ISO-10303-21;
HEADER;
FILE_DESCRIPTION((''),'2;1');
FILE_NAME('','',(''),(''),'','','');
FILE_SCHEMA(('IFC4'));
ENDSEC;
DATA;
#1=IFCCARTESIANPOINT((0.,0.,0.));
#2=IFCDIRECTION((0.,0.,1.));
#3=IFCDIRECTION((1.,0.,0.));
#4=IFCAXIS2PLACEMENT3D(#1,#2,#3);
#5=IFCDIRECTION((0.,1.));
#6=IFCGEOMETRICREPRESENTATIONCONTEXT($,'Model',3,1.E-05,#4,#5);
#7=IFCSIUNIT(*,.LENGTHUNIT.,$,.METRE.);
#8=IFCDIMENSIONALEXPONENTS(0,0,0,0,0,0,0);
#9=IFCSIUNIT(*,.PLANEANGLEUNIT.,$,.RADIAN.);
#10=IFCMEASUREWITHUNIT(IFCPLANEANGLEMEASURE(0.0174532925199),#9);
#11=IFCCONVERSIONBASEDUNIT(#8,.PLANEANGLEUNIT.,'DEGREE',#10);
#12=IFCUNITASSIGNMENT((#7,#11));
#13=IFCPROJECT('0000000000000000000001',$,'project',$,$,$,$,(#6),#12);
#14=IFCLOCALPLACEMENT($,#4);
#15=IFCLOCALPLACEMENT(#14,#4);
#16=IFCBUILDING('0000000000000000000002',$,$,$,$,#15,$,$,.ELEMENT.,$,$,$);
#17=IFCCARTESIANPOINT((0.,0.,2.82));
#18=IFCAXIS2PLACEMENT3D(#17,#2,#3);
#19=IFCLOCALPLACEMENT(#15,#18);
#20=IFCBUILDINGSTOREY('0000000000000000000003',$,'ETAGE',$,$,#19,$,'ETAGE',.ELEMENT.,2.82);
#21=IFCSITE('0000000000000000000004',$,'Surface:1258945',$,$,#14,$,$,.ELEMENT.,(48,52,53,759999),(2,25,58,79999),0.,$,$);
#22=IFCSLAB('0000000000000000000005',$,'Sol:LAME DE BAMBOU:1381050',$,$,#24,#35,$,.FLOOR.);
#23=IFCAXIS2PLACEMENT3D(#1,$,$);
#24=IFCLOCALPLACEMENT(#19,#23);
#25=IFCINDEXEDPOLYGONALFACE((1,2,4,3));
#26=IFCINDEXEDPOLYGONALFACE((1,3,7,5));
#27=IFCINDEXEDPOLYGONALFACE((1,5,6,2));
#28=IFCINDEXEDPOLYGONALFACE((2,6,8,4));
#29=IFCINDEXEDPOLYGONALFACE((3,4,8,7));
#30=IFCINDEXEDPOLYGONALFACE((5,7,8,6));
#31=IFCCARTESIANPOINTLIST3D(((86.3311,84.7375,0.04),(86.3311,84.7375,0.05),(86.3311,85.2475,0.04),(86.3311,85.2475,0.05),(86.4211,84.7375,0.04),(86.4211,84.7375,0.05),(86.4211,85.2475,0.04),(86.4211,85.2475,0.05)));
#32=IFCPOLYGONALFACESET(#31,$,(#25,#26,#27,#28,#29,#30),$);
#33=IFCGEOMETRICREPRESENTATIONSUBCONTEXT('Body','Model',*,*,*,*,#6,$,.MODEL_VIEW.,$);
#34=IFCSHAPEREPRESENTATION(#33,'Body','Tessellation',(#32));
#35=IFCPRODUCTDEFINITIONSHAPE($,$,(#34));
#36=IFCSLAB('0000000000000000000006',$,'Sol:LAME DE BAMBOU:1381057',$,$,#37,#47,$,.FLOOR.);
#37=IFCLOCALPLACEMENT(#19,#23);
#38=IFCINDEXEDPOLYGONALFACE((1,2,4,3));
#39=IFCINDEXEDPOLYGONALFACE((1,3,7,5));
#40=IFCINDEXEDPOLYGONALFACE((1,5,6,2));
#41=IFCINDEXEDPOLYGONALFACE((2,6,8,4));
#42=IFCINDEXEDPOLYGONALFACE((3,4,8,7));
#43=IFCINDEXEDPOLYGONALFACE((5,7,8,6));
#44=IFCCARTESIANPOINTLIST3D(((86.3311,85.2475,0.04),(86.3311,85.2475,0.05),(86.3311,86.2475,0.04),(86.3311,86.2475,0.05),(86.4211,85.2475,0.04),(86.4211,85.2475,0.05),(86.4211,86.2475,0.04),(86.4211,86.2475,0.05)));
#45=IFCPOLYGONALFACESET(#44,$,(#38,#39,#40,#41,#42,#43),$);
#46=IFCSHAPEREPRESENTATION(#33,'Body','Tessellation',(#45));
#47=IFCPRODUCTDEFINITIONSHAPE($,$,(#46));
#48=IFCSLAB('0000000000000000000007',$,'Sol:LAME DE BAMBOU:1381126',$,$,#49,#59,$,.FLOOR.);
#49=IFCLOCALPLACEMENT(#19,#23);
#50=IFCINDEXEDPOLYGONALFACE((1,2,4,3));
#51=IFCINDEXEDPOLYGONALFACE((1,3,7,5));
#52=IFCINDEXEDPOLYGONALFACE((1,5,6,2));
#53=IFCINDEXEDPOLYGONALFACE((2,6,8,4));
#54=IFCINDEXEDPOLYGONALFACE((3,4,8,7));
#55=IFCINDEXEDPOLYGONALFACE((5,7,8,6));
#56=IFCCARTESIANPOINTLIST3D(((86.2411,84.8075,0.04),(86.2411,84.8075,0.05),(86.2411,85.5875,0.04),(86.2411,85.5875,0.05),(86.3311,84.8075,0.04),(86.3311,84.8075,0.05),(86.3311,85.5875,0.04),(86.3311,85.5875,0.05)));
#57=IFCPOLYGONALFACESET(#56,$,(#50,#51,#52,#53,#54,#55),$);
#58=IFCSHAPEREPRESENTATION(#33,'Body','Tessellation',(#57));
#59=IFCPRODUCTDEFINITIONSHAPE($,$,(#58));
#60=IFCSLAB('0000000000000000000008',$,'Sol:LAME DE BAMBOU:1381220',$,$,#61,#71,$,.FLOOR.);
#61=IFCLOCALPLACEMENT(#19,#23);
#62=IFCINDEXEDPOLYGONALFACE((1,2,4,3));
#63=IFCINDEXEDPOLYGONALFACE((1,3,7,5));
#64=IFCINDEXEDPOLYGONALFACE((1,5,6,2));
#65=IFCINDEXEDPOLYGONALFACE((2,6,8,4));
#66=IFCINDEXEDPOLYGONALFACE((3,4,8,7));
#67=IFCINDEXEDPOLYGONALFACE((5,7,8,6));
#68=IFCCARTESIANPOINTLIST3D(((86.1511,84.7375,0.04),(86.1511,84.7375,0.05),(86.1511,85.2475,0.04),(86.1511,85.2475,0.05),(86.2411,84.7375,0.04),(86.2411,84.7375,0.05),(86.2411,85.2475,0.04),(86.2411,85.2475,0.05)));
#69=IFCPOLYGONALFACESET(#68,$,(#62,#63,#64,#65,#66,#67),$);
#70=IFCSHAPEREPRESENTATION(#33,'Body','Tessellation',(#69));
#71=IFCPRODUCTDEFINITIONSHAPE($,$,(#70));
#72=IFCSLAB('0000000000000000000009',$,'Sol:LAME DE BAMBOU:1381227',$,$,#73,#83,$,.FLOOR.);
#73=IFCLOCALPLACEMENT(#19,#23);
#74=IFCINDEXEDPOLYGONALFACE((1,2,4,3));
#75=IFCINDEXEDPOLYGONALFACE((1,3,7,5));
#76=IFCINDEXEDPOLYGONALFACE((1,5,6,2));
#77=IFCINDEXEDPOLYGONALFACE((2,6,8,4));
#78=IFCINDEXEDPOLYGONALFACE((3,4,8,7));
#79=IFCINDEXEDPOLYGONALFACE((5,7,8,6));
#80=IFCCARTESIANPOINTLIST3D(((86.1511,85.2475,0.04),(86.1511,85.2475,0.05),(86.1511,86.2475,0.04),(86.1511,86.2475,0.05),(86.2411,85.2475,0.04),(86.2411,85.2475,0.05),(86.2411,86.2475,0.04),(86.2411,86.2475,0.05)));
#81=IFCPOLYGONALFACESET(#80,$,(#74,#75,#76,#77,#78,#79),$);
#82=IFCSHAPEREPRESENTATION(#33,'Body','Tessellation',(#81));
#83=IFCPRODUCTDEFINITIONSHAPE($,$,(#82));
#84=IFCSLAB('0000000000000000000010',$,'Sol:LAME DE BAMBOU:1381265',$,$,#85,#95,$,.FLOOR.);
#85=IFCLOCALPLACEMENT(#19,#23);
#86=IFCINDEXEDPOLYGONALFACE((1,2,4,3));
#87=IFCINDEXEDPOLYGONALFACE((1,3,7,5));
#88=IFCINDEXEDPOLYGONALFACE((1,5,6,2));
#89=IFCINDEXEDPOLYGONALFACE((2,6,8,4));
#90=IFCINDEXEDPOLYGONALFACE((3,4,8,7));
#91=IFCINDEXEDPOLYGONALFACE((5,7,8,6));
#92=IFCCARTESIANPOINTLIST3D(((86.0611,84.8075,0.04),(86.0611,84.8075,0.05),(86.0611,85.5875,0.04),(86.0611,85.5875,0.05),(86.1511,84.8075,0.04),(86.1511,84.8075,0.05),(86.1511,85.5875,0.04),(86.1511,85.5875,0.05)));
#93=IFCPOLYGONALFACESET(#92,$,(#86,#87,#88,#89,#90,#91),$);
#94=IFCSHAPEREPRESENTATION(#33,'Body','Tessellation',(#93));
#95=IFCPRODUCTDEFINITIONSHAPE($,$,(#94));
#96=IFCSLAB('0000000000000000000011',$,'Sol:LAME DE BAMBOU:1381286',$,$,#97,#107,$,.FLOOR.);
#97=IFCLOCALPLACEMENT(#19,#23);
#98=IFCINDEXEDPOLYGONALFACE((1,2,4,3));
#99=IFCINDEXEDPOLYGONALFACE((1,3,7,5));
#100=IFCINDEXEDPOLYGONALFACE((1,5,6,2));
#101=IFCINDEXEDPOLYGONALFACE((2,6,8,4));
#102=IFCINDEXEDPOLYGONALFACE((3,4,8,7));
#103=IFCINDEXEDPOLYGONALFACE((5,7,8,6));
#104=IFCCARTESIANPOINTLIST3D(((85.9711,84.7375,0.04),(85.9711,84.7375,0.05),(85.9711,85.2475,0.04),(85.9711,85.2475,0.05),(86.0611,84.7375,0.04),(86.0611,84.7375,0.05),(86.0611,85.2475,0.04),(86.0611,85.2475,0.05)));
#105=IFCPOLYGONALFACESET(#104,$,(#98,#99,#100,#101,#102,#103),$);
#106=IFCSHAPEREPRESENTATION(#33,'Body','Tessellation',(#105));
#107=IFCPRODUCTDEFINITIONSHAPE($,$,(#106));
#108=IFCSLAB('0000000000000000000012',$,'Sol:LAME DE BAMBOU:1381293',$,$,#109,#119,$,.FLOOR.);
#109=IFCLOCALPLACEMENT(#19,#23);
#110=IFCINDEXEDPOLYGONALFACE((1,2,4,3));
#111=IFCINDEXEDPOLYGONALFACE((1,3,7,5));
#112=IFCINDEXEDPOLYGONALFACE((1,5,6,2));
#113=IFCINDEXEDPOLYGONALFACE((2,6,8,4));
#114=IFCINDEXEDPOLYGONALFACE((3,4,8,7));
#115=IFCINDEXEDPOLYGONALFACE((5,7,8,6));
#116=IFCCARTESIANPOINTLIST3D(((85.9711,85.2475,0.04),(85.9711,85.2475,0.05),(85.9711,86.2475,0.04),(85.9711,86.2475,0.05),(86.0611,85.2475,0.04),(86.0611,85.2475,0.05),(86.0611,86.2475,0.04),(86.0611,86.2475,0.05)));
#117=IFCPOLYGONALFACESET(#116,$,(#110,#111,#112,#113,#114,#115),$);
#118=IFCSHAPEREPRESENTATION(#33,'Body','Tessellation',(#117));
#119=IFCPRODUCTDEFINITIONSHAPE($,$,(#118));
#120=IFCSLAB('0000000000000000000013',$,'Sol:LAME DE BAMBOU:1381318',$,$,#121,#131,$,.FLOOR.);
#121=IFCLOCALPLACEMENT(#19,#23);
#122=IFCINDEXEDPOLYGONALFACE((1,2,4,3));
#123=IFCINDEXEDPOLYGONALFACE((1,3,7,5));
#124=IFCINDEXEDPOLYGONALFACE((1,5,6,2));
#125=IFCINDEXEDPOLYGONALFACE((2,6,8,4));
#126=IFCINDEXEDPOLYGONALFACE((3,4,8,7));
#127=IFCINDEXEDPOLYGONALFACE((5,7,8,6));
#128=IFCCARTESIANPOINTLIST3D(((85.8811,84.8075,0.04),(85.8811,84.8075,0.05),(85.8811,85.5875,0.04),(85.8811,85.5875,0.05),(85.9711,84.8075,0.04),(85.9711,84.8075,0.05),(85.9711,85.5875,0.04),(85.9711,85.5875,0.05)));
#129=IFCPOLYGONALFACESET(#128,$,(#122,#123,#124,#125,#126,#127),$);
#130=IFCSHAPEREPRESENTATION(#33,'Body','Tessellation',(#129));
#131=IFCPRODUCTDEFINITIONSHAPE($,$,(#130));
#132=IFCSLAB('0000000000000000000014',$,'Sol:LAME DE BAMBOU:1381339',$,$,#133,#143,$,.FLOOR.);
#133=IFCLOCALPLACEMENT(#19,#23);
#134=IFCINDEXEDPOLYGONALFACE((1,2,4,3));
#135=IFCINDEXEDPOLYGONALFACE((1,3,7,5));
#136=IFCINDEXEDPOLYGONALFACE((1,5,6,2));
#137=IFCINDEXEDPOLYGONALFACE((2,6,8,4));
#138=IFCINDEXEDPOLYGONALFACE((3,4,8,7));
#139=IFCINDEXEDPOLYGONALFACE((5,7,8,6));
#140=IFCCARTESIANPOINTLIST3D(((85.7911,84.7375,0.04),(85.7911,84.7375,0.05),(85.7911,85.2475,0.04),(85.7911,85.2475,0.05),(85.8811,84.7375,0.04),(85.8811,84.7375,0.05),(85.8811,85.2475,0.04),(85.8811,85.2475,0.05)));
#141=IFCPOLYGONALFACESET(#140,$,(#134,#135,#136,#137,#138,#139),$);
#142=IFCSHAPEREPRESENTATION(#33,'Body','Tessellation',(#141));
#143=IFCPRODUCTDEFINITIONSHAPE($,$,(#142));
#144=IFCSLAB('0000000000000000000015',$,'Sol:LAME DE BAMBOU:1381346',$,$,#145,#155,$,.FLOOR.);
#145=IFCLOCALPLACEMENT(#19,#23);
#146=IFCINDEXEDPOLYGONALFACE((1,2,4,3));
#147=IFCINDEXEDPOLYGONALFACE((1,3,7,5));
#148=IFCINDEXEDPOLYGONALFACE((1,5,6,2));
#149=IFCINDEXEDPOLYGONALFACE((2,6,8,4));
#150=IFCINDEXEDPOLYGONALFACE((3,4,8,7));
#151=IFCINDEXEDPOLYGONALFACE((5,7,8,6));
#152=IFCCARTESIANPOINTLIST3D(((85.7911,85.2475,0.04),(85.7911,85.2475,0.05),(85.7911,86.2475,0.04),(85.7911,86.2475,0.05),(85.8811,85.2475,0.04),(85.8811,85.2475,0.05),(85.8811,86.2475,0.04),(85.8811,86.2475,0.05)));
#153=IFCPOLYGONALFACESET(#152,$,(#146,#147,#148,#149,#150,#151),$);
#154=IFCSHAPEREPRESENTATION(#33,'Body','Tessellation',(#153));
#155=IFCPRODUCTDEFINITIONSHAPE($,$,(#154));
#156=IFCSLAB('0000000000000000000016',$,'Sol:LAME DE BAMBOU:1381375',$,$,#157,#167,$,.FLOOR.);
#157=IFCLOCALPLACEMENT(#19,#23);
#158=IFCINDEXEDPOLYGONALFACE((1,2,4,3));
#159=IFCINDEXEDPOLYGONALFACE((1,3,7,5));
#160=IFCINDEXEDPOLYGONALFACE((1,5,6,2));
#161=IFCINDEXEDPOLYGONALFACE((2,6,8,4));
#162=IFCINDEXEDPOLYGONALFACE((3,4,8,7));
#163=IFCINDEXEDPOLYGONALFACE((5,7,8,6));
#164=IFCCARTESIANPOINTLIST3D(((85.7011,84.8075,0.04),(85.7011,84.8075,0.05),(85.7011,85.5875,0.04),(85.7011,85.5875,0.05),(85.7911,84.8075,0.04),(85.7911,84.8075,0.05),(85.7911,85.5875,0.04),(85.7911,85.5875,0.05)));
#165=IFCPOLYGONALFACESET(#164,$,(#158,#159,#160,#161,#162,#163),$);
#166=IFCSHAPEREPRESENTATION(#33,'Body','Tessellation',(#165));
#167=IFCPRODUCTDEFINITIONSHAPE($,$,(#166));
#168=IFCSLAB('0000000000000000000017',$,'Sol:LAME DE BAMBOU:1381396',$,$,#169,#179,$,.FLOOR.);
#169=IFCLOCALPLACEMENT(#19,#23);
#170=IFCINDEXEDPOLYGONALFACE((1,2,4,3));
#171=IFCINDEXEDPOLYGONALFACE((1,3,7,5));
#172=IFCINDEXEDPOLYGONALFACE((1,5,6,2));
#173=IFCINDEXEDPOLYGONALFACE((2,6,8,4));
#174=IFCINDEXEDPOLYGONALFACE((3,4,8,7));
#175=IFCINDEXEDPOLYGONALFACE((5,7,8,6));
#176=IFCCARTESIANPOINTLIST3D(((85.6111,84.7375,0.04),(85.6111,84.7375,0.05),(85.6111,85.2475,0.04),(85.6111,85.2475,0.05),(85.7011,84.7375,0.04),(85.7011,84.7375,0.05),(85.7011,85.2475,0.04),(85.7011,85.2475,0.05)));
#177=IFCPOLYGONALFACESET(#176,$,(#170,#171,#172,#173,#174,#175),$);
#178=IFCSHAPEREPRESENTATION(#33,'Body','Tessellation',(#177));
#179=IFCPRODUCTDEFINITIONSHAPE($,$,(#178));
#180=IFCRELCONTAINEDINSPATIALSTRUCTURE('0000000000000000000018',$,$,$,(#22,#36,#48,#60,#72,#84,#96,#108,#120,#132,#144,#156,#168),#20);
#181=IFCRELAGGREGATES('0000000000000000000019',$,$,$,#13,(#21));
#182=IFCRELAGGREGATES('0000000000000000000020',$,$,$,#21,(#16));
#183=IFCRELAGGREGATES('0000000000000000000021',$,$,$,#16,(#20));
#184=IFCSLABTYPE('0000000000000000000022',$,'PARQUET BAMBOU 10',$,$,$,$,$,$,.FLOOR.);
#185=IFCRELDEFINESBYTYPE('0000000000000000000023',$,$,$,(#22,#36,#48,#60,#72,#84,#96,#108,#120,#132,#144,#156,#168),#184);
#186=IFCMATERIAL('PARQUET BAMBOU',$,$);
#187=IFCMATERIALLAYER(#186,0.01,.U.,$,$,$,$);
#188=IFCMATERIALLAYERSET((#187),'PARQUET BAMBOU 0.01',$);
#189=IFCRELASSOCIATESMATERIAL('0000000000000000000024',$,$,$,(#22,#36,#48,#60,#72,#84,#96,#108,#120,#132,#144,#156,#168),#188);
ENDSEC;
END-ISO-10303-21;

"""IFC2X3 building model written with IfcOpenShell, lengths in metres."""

from ifc_helpers import new_model, entity, si_unit, converted_unit, direction, frame, origin_with_axes, place, context, subcontext, project, spatial, polyline, outline, extrude, material, layer, layer_set, layer_usage, type_object, element, save


model = new_model("IFC2X3")

# Units and contexts
model_context = context("Model", 3, precision=1e-05, world=origin_with_axes(), true_north=direction((0.0, 1.0)))
body_context = subcontext(model_context, "Body", "Model", "MODEL_VIEW")
ifc_project = project(units=[si_unit("LENGTHUNIT", "METRE"), converted_unit("PLANEANGLEUNIT", "DEGREE", entity("IfcPlaneAngleMeasure", 0.0174532925199), si_unit("PLANEANGLEUNIT", "RADIAN"), dimensions=[0, 0, 0, 0, 0, 0, 0])], contexts=[model_context])

# Site, building, storey
site_placement = place(None, origin_with_axes())
site = spatial("IfcSite", under=ifc_project, at=site_placement, Name="Surface:1258945", CompositionType="ELEMENT", RefLatitude=(48, 52, 53, 759999), RefLongitude=(2, 25, 58, 79999), RefElevation=0.0)
building_placement = place(site_placement, origin_with_axes())
building = spatial("IfcBuilding", under=site, at=building_placement, CompositionType="ELEMENT")
storey_placement = place(building_placement, frame((0.0, 0.0, 2.82), z_axis=(0.0, 0.0, 1.0), x_axis=(1.0, 0.0, 0.0)))
storey = spatial("IfcBuildingStorey", under=building, at=storey_placement, Name="ETAGE", LongName="ETAGE", CompositionType="ELEMENT", Elevation=2.82)

# Slabs
ifc_material = material(Name="PARQUET BAMBOU")
ifc_layer = layer(ifc_material, 0.01, ventilated="UNKNOWN")
ifc_layer_set = layer_set([ifc_layer], Name="PARQUET BAMBOU 0.01")
ifc_layer_usage_1 = layer_usage(ifc_layer_set, "AXIS3", "NEGATIVE", 0.01)
slab_type = type_object("IfcSlabType", Name="PARQUET BAMBOU 10", PredefinedType="FLOOR")
slab_1_placement = place(storey_placement, frame((86.3311, 85.2475, 0.05), z_axis=(0.0, 0.0, 1.0), x_axis=(1.0, 0.0, 0.0)))
element("IfcSlab", 1, at=slab_1_placement, inside=storey, type_object=slab_type, material=ifc_layer_usage_1, Name="Sol:LAME DE BAMBOU:1381050", PredefinedType="FLOOR", context=body_context, shape_type="SweptSolid", body=[
    extrude(outline(polyline([(0.0, 0.0), (0.0, -0.51), (0.09, -0.51), (0.09, 0.0), (0.0, 0.0)])), frame((0.0, 0.0, -0.01), z_axis=(0.0, 0.0, 1.0), x_axis=(1.0, 0.0, 0.0)), (0.0, 0.0, 1.0), 0.01),
])
ifc_layer_usage_2 = layer_usage(ifc_layer_set, "AXIS3", "NEGATIVE", 0.01)
slab_2_placement = place(storey_placement, frame((86.3311, 86.2475, 0.05), z_axis=(0.0, 0.0, 1.0), x_axis=(1.0, 0.0, 0.0)))
element("IfcSlab", 2, at=slab_2_placement, inside=storey, type_object=slab_type, material=ifc_layer_usage_2, Name="Sol:LAME DE BAMBOU:1381057", PredefinedType="FLOOR", context=body_context, shape_type="SweptSolid", body=[
    extrude(outline(polyline([(0.0, 0.0), (0.0, -1.0), (0.09, -1.0), (0.09, 0.0), (0.0, 0.0)])), frame((0.0, 0.0, -0.01), z_axis=(0.0, 0.0, 1.0), x_axis=(1.0, 0.0, 0.0)), (0.0, 0.0, 1.0), 0.01),
])
ifc_layer_usage_3 = layer_usage(ifc_layer_set, "AXIS3", "NEGATIVE", 0.01)
slab_3_placement = place(storey_placement, frame((86.2411, 85.5875, 0.05), z_axis=(0.0, 0.0, 1.0), x_axis=(1.0, 0.0, 0.0)))
element("IfcSlab", 3, at=slab_3_placement, inside=storey, type_object=slab_type, material=ifc_layer_usage_3, Name="Sol:LAME DE BAMBOU:1381126", PredefinedType="FLOOR", context=body_context, shape_type="SweptSolid", body=[
    extrude(outline(polyline([(0.0, 0.0), (0.0, -0.78), (0.09, -0.78), (0.09, 0.0), (0.0, 0.0)])), frame((0.0, 0.0, -0.01), z_axis=(0.0, 0.0, 1.0), x_axis=(1.0, 0.0, 0.0)), (0.0, 0.0, 1.0), 0.01),
])
ifc_layer_usage_4 = layer_usage(ifc_layer_set, "AXIS3", "NEGATIVE", 0.01)
slab_4_placement = place(storey_placement, frame((86.1511, 85.2475, 0.05), z_axis=(0.0, 0.0, 1.0), x_axis=(1.0, 0.0, 0.0)))
element("IfcSlab", 4, at=slab_4_placement, inside=storey, type_object=slab_type, material=ifc_layer_usage_4, Name="Sol:LAME DE BAMBOU:1381220", PredefinedType="FLOOR", context=body_context, shape_type="SweptSolid", body=[
    extrude(outline(polyline([(0.0, 0.0), (0.0, -0.51), (0.09, -0.51), (0.09, 0.0), (0.0, 0.0)])), frame((0.0, 0.0, -0.01), z_axis=(0.0, 0.0, 1.0), x_axis=(1.0, 0.0, 0.0)), (0.0, 0.0, 1.0), 0.01),
])
ifc_layer_usage_5 = layer_usage(ifc_layer_set, "AXIS3", "NEGATIVE", 0.01)
slab_5_placement = place(storey_placement, frame((86.1511, 86.2475, 0.05), z_axis=(0.0, 0.0, 1.0), x_axis=(1.0, 0.0, 0.0)))
element("IfcSlab", 5, at=slab_5_placement, inside=storey, type_object=slab_type, material=ifc_layer_usage_5, Name="Sol:LAME DE BAMBOU:1381227", PredefinedType="FLOOR", context=body_context, shape_type="SweptSolid", body=[
    extrude(outline(polyline([(0.0, 0.0), (0.0, -1.0), (0.09, -1.0), (0.09, 0.0), (0.0, 0.0)])), frame((0.0, 0.0, -0.01), z_axis=(0.0, 0.0, 1.0), x_axis=(1.0, 0.0, 0.0)), (0.0, 0.0, 1.0), 0.01),
])
ifc_layer_usage_6 = layer_usage(ifc_layer_set, "AXIS3", "NEGATIVE", 0.01)
slab_6_placement = place(storey_placement, frame((86.0611, 85.5875, 0.05), z_axis=(0.0, 0.0, 1.0), x_axis=(1.0, 0.0, 0.0)))
element("IfcSlab", 6, at=slab_6_placement, inside=storey, type_object=slab_type, material=ifc_layer_usage_6, Name="Sol:LAME DE BAMBOU:1381265", PredefinedType="FLOOR", context=body_context, shape_type="SweptSolid", body=[
    extrude(outline(polyline([(0.0, 0.0), (0.0, -0.78), (0.09, -0.78), (0.09, 0.0), (0.0, 0.0)])), frame((0.0, 0.0, -0.01), z_axis=(0.0, 0.0, 1.0), x_axis=(1.0, 0.0, 0.0)), (0.0, 0.0, 1.0), 0.01),
])
ifc_layer_usage_7 = layer_usage(ifc_layer_set, "AXIS3", "NEGATIVE", 0.01)
slab_7_placement = place(storey_placement, frame((85.9711, 85.2475, 0.05), z_axis=(0.0, 0.0, 1.0), x_axis=(1.0, 0.0, 0.0)))
element("IfcSlab", 7, at=slab_7_placement, inside=storey, type_object=slab_type, material=ifc_layer_usage_7, Name="Sol:LAME DE BAMBOU:1381286", PredefinedType="FLOOR", context=body_context, shape_type="SweptSolid", body=[
    extrude(outline(polyline([(0.0, 0.0), (0.0, -0.51), (0.09, -0.51), (0.09, 0.0), (0.0, 0.0)])), frame((0.0, 0.0, -0.01), z_axis=(0.0, 0.0, 1.0), x_axis=(1.0, 0.0, 0.0)), (0.0, 0.0, 1.0), 0.01),
])
ifc_layer_usage_8 = layer_usage(ifc_layer_set, "AXIS3", "NEGATIVE", 0.01)
slab_8_placement = place(storey_placement, frame((85.9711, 86.2475, 0.05), z_axis=(0.0, 0.0, 1.0), x_axis=(1.0, 0.0, 0.0)))
element("IfcSlab", 8, at=slab_8_placement, inside=storey, type_object=slab_type, material=ifc_layer_usage_8, Name="Sol:LAME DE BAMBOU:1381293", PredefinedType="FLOOR", context=body_context, shape_type="SweptSolid", body=[
    extrude(outline(polyline([(0.0, 0.0), (0.0, -1.0), (0.09, -1.0), (0.09, 0.0), (0.0, 0.0)])), frame((0.0, 0.0, -0.01), z_axis=(0.0, 0.0, 1.0), x_axis=(1.0, 0.0, 0.0)), (0.0, 0.0, 1.0), 0.01),
])
ifc_layer_usage_9 = layer_usage(ifc_layer_set, "AXIS3", "NEGATIVE", 0.01)
slab_9_placement = place(storey_placement, frame((85.8811, 85.5875, 0.05), z_axis=(0.0, 0.0, 1.0), x_axis=(1.0, 0.0, 0.0)))
element("IfcSlab", 9, at=slab_9_placement, inside=storey, type_object=slab_type, material=ifc_layer_usage_9, Name="Sol:LAME DE BAMBOU:1381318", PredefinedType="FLOOR", context=body_context, shape_type="SweptSolid", body=[
    extrude(outline(polyline([(0.0, 0.0), (0.0, -0.78), (0.09, -0.78), (0.09, 0.0), (0.0, 0.0)])), frame((0.0, 0.0, -0.01), z_axis=(0.0, 0.0, 1.0), x_axis=(1.0, 0.0, 0.0)), (0.0, 0.0, 1.0), 0.01),
])
ifc_layer_usage_10 = layer_usage(ifc_layer_set, "AXIS3", "NEGATIVE", 0.01)
slab_10_placement = place(storey_placement, frame((85.7911, 85.2475, 0.05), z_axis=(0.0, 0.0, 1.0), x_axis=(1.0, 0.0, 0.0)))
element("IfcSlab", 10, at=slab_10_placement, inside=storey, type_object=slab_type, material=ifc_layer_usage_10, Name="Sol:LAME DE BAMBOU:1381339", PredefinedType="FLOOR", context=body_context, shape_type="SweptSolid", body=[
    extrude(outline(polyline([(0.0, 0.0), (0.0, -0.51), (0.09, -0.51), (0.09, 0.0), (0.0, 0.0)])), frame((0.0, 0.0, -0.01), z_axis=(0.0, 0.0, 1.0), x_axis=(1.0, 0.0, 0.0)), (0.0, 0.0, 1.0), 0.01),
])
ifc_layer_usage_11 = layer_usage(ifc_layer_set, "AXIS3", "NEGATIVE", 0.01)
slab_11_placement = place(storey_placement, frame((85.7911, 86.2475, 0.05), z_axis=(0.0, 0.0, 1.0), x_axis=(1.0, 0.0, 0.0)))
element("IfcSlab", 11, at=slab_11_placement, inside=storey, type_object=slab_type, material=ifc_layer_usage_11, Name="Sol:LAME DE BAMBOU:1381346", PredefinedType="FLOOR", context=body_context, shape_type="SweptSolid", body=[
    extrude(outline(polyline([(0.0, 0.0), (0.0, -1.0), (0.09, -1.0), (0.09, 0.0), (0.0, 0.0)])), frame((0.0, 0.0, -0.01), z_axis=(0.0, 0.0, 1.0), x_axis=(1.0, 0.0, 0.0)), (0.0, 0.0, 1.0), 0.01),
])
ifc_layer_usage_12 = layer_usage(ifc_layer_set, "AXIS3", "NEGATIVE", 0.01)
slab_12_placement = place(storey_placement, frame((85.7011, 85.5875, 0.05), z_axis=(0.0, 0.0, 1.0), x_axis=(1.0, 0.0, 0.0)))
element("IfcSlab", 12, at=slab_12_placement, inside=storey, type_object=slab_type, material=ifc_layer_usage_12, Name="Sol:LAME DE BAMBOU:1381375", PredefinedType="FLOOR", context=body_context, shape_type="SweptSolid", body=[
    extrude(outline(polyline([(0.0, 0.0), (0.0, -0.78), (0.09, -0.78), (0.09, 0.0), (0.0, 0.0)])), frame((0.0, 0.0, -0.01), z_axis=(0.0, 0.0, 1.0), x_axis=(1.0, 0.0, 0.0)), (0.0, 0.0, 1.0), 0.01),
])
ifc_layer_usage_13 = layer_usage(ifc_layer_set, "AXIS3", "NEGATIVE", 0.01)
slab_13_placement = place(storey_placement, frame((85.6111, 85.2475, 0.05), z_axis=(0.0, 0.0, 1.0), x_axis=(1.0, 0.0, 0.0)))
element("IfcSlab", 13, at=slab_13_placement, inside=storey, type_object=slab_type, material=ifc_layer_usage_13, Name="Sol:LAME DE BAMBOU:1381396", PredefinedType="FLOOR", context=body_context, shape_type="SweptSolid", body=[
    extrude(outline(polyline([(0.0, 0.0), (0.0, -0.51), (0.09, -0.51), (0.09, 0.0), (0.0, 0.0)])), frame((0.0, 0.0, -0.01), z_axis=(0.0, 0.0, 1.0), x_axis=(1.0, 0.0, 0.0)), (0.0, 0.0, 1.0), 0.01),
])

save(model, "model.ifc")
